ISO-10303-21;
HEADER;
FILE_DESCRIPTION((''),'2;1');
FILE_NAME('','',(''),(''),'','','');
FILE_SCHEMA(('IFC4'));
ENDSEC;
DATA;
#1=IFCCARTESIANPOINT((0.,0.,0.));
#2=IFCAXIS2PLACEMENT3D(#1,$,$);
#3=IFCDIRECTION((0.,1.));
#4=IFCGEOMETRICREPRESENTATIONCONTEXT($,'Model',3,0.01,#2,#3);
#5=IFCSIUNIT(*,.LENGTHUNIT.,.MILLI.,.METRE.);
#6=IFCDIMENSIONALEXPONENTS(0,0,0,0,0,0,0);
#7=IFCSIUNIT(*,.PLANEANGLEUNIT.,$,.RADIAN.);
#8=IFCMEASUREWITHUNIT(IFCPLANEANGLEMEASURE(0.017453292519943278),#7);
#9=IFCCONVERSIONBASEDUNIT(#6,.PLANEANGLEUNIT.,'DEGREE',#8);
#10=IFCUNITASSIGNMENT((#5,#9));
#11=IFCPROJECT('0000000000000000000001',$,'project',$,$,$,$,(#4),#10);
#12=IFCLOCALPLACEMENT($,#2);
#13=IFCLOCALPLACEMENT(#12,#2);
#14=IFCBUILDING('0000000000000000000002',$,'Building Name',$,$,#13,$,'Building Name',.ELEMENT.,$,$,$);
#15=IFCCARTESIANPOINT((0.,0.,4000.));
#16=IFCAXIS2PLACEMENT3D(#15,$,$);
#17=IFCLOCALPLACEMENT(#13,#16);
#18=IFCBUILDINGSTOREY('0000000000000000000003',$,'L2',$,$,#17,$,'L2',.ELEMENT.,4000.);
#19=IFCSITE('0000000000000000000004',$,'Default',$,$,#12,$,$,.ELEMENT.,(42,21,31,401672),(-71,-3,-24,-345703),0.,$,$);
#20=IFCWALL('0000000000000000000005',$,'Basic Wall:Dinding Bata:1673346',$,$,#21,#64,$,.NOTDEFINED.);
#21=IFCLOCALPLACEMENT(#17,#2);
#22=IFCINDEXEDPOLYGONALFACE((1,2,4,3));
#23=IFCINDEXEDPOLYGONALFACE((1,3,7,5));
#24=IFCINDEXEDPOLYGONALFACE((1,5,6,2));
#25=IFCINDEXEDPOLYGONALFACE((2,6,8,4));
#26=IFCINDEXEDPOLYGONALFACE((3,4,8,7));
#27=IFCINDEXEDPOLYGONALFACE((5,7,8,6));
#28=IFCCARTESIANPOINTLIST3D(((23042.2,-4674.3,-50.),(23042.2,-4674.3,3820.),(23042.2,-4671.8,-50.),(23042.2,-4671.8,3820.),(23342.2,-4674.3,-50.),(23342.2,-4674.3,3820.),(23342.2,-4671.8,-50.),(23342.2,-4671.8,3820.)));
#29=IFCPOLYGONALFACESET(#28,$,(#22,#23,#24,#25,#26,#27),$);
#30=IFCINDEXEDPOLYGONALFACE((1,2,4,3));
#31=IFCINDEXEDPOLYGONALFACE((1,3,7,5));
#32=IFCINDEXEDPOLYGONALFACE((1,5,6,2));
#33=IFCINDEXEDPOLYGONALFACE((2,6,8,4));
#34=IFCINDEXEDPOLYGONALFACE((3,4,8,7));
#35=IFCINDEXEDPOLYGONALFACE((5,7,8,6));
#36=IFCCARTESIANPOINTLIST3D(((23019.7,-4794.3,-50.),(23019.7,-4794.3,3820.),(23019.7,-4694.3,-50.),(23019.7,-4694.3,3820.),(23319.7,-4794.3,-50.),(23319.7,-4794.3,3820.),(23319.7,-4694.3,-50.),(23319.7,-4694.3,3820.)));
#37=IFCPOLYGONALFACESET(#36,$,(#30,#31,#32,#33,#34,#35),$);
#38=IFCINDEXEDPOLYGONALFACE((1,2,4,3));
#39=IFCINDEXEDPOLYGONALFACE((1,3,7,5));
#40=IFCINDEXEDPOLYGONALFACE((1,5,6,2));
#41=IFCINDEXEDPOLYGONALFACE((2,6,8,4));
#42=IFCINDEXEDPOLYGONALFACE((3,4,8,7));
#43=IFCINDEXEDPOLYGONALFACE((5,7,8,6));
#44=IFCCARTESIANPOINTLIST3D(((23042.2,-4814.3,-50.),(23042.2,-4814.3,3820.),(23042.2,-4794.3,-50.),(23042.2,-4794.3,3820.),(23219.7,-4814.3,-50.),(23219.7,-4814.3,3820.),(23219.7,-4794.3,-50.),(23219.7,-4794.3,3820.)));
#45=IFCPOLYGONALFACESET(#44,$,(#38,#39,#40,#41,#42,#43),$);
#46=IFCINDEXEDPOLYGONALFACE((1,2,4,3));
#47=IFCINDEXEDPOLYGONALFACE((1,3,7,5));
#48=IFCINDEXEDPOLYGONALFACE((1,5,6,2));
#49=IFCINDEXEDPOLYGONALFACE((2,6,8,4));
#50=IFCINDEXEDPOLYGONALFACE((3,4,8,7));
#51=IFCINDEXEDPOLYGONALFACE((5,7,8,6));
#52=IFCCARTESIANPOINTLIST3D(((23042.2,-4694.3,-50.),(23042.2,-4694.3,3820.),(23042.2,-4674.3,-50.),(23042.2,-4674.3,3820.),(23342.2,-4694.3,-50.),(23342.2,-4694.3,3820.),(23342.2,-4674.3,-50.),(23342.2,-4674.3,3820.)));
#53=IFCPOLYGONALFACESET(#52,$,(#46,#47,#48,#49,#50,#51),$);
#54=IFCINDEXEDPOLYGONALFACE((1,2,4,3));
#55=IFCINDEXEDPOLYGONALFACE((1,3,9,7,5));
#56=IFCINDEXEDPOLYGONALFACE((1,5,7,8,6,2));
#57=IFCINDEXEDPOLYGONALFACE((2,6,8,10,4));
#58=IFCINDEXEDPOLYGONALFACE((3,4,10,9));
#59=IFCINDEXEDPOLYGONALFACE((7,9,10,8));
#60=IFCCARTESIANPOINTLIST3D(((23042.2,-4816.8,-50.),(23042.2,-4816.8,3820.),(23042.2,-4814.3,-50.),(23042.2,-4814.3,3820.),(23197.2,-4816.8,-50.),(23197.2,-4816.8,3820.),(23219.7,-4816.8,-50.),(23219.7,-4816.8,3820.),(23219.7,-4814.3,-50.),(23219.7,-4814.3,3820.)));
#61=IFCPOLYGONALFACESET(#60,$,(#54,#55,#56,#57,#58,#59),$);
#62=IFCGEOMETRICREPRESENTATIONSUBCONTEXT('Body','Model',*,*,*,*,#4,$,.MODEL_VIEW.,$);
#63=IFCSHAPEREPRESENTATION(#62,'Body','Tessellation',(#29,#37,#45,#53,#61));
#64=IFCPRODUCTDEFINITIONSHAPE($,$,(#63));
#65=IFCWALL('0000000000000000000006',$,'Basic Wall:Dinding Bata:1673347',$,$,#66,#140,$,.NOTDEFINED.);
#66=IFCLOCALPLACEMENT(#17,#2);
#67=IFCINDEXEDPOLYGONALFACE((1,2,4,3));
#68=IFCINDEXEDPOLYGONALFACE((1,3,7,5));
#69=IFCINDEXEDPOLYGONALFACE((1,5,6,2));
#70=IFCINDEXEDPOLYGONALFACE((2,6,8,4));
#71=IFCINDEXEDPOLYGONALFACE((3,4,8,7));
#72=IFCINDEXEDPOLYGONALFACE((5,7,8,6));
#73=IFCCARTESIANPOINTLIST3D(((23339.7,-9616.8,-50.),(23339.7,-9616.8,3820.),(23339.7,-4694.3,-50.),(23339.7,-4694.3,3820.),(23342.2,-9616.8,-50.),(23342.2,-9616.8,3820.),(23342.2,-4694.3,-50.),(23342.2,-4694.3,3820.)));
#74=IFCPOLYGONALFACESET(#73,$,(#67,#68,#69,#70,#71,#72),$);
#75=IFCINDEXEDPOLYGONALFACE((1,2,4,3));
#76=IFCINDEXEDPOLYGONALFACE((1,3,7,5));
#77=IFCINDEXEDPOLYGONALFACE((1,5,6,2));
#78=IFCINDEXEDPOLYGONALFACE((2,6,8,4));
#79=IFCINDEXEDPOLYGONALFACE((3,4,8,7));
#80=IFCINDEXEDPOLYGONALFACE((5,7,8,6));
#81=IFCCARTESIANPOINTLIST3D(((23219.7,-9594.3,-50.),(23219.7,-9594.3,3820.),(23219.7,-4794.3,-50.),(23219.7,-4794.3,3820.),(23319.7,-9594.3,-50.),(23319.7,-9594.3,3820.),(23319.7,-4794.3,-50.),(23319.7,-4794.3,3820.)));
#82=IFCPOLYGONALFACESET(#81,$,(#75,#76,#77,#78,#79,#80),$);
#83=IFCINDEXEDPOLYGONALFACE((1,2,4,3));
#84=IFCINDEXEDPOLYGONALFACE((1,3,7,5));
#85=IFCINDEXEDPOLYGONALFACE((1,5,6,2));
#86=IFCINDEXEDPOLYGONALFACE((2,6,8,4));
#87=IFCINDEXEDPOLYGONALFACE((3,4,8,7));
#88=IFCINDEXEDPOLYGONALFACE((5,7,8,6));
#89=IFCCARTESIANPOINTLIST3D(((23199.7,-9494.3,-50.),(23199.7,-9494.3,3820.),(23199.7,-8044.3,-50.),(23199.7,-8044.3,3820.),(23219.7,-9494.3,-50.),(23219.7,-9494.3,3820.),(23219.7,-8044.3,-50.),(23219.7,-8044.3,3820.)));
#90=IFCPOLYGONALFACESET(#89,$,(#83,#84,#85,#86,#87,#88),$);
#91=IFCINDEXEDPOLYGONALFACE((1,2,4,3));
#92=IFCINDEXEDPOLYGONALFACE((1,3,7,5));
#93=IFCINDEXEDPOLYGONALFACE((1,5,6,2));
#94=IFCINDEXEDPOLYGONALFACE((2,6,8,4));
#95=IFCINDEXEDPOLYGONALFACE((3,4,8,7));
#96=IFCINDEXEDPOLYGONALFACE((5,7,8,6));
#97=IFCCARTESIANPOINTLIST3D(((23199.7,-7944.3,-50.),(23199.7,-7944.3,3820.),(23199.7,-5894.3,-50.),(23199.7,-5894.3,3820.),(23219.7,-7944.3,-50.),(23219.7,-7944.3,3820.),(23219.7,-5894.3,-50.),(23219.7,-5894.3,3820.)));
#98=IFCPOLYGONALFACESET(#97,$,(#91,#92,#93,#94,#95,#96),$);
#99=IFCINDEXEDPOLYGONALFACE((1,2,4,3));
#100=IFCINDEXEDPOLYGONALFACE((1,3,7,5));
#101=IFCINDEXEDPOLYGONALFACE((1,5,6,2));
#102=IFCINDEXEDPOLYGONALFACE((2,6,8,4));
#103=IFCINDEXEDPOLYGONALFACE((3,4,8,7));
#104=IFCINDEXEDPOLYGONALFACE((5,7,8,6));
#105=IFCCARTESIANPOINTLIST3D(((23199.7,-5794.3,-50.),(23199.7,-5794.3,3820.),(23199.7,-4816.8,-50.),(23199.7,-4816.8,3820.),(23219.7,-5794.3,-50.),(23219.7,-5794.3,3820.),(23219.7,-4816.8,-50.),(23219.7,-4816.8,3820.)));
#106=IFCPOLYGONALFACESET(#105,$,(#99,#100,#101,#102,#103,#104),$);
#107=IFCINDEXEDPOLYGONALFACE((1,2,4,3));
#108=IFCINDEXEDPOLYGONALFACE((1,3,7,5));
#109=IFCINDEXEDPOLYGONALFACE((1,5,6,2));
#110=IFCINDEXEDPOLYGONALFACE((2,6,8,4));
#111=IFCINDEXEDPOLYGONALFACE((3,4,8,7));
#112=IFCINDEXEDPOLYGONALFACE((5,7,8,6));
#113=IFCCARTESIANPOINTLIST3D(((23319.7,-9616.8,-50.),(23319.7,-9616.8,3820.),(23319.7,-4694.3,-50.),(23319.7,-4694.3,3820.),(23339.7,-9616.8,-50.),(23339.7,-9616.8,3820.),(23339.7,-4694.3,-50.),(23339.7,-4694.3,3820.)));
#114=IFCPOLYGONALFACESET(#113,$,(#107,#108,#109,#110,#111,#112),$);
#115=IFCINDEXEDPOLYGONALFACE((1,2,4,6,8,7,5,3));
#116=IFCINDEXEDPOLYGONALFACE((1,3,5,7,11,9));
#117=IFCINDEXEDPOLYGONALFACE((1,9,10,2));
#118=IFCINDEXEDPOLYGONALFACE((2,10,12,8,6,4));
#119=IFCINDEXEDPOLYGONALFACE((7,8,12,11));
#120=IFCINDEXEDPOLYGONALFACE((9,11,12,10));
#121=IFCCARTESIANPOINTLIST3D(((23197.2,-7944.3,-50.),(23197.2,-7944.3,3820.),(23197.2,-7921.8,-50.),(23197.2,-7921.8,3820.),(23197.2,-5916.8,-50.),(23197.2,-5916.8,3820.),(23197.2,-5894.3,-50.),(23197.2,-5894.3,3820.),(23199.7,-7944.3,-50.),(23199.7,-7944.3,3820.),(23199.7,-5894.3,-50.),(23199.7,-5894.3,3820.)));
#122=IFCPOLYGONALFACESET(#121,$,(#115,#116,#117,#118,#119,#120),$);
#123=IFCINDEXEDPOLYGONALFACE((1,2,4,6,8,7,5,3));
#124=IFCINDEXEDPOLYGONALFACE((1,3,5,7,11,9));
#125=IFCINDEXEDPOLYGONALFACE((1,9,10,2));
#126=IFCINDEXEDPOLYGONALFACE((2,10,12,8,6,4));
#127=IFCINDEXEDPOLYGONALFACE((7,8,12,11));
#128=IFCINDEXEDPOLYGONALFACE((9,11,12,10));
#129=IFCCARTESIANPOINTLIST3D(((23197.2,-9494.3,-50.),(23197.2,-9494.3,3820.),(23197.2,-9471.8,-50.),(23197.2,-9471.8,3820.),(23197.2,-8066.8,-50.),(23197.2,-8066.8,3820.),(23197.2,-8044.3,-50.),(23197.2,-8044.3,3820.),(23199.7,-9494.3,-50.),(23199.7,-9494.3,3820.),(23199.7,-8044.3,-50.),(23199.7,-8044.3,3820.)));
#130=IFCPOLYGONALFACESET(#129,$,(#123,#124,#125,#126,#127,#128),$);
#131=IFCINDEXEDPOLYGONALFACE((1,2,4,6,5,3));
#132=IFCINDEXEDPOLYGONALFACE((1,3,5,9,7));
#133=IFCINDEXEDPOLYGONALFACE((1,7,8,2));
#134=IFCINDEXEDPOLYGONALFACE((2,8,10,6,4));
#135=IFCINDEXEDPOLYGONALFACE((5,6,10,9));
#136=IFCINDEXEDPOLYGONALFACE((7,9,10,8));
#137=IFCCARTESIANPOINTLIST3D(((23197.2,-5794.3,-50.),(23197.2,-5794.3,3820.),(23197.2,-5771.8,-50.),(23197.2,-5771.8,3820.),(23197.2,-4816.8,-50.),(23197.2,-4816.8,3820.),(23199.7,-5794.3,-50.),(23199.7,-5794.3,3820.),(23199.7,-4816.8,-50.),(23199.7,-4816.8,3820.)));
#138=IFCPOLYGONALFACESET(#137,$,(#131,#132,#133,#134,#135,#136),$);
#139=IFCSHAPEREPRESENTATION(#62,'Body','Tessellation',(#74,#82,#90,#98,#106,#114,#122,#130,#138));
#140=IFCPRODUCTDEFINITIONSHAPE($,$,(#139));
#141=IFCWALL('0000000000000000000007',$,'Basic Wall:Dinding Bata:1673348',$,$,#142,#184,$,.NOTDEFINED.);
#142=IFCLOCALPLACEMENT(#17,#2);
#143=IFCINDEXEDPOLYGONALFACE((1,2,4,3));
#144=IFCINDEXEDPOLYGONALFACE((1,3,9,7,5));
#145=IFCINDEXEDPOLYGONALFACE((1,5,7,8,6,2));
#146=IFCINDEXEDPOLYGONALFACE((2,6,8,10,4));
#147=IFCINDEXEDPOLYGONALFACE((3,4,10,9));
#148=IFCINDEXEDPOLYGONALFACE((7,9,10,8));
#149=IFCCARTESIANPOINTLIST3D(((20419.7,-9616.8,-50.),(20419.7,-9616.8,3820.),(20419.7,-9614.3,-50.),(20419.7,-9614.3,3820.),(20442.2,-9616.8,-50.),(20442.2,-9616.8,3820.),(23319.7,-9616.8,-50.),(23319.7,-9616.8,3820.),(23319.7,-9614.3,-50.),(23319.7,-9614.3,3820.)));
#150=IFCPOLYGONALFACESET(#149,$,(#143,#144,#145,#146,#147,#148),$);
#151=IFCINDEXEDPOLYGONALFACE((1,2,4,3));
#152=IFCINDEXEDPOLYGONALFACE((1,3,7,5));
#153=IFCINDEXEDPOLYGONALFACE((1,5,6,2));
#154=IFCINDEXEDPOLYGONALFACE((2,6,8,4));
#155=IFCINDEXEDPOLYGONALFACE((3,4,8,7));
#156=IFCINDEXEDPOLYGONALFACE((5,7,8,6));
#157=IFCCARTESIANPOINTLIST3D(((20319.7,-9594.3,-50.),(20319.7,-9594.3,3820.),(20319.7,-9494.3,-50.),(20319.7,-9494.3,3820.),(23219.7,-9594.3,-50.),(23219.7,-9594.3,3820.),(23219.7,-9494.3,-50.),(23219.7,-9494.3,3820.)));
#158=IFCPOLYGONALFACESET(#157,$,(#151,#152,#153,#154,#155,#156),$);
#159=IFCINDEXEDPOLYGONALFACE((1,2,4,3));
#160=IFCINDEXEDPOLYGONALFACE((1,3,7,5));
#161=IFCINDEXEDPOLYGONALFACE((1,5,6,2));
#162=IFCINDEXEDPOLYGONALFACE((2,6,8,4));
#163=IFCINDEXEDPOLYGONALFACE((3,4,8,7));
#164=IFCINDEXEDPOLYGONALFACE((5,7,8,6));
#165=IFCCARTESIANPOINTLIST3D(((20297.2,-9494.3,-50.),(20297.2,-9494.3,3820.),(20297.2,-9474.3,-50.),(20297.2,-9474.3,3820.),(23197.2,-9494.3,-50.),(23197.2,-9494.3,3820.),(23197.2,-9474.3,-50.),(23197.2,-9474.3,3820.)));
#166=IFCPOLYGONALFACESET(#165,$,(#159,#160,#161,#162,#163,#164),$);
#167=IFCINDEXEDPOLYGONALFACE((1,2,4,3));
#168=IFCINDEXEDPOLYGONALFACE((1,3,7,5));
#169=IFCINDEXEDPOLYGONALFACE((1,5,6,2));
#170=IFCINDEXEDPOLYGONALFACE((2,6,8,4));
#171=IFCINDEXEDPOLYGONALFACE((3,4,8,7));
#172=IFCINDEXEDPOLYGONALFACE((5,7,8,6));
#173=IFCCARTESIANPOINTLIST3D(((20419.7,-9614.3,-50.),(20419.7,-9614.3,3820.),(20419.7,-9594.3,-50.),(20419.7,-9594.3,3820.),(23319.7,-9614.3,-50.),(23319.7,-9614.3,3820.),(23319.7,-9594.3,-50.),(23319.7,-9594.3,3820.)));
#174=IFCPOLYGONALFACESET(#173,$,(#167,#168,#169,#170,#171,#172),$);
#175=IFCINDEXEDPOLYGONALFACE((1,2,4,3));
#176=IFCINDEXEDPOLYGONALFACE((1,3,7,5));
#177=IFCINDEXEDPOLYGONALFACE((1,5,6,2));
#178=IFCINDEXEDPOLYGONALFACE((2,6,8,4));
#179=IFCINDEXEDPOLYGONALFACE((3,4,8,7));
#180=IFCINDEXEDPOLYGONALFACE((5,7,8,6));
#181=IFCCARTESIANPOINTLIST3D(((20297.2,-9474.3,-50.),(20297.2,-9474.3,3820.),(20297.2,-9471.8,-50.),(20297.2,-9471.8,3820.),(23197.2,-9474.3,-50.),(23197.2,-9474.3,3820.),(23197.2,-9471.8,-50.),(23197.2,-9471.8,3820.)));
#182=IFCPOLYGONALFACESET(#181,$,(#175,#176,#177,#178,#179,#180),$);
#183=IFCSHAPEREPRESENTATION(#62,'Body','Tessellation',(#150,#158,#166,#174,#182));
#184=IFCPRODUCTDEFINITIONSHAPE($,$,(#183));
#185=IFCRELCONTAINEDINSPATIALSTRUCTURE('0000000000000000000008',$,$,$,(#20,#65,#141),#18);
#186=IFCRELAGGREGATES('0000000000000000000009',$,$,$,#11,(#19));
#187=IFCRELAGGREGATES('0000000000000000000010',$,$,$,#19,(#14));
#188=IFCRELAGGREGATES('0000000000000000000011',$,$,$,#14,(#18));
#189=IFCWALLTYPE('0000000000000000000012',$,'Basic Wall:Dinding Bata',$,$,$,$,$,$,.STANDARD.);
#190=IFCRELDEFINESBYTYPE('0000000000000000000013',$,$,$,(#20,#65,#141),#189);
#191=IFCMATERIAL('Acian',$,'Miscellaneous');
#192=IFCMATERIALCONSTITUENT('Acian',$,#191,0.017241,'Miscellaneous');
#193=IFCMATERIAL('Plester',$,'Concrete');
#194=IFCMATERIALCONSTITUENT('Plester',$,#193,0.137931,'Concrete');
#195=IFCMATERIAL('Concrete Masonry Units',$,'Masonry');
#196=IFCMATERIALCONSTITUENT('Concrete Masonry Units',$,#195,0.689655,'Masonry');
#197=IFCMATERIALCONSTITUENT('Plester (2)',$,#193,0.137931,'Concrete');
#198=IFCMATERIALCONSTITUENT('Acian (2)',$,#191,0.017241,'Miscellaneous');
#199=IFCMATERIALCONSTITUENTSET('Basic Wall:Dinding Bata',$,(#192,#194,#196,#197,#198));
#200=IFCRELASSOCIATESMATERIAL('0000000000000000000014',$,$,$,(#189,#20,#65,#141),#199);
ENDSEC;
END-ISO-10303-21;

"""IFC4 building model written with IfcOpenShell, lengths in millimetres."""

from ifc_helpers import new_model, entity, si_unit, converted_unit, direction, frame, origin, place, context, subcontext, project, spatial, indexed_curve, outline, extrude, material, constituent, constituent_set, type_object, element, save


model = new_model("IFC4")

# Units and contexts
model_context = context("Model", 3, precision=0.01, world=origin(), true_north=direction((0.0, 1.0)))
body_context = subcontext(model_context, "Body", "Model", "MODEL_VIEW")
ifc_project = project(units=[si_unit("LENGTHUNIT", "METRE", prefix="MILLI"), converted_unit("PLANEANGLEUNIT", "DEGREE", entity("IfcPlaneAngleMeasure", 0.017453292519943278), si_unit("PLANEANGLEUNIT", "RADIAN"), dimensions=[0, 0, 0, 0, 0, 0, 0])], contexts=[model_context])

# Site, building, storey
site_placement = place(None, origin())
site = spatial("IfcSite", under=ifc_project, at=site_placement, Name="Default", CompositionType="ELEMENT", RefLatitude=(42, 21, 31, 401672), RefLongitude=(-71, -3, -24, -345703), RefElevation=0.0)
building_placement = place(site_placement, origin())
building = spatial("IfcBuilding", under=site, at=building_placement, Name="Building Name", LongName="Building Name", CompositionType="ELEMENT")
storey_placement = place(building_placement, frame((0.0, 0.0, 4000.0)))
storey = spatial("IfcBuildingStorey", under=building, at=storey_placement, Name="L2", LongName="L2", CompositionType="ELEMENT", Elevation=4000.0)

# Walls
ifc_material_1 = material(Name="Acian", Category="Miscellaneous")
ifc_constituent_1 = constituent(ifc_material_1, Name="Acian", Category="Miscellaneous", fraction=0.017241)
ifc_material_2 = material(Name="Plester", Category="Concrete")
ifc_constituent_2 = constituent(ifc_material_2, Name="Plester", Category="Concrete", fraction=0.137931)
ifc_material_3 = material(Name="Concrete Masonry Units", Category="Masonry")
ifc_constituent_3 = constituent(ifc_material_3, Name="Concrete Masonry Units", Category="Masonry", fraction=0.689655)
ifc_constituent_4 = constituent(ifc_material_2, Name="Plester (2)", Category="Concrete", fraction=0.137931)
ifc_constituent_5 = constituent(ifc_material_1, Name="Acian (2)", Category="Miscellaneous", fraction=0.017241)
ifc_constituent_set = constituent_set(constituents=[ifc_constituent_1, ifc_constituent_2, ifc_constituent_3, ifc_constituent_4, ifc_constituent_5], Name="Basic Wall:Dinding Bata")
wall_type = type_object("IfcWallType", Name="Basic Wall:Dinding Bata", PredefinedType="STANDARD", material=ifc_constituent_set)
wall_1_placement = place(storey_placement, frame((23042.2, -4744.3, -50.0)))
element("IfcWall", 1, at=wall_1_placement, inside=storey, type_object=wall_type, material=ifc_constituent_set, Name="Basic Wall:Dinding Bata:1673346", PredefinedType="NOTDEFINED", context=body_context, shape_type="SweptSolid", body=[
    extrude(outline(indexed_curve([(-1.3, -150.0), (1.2, -150.0), (1.3, 150.0), (-1.2, 150.0), (-1.3, -150.0)], self_intersect=False)), frame((150.0, 71.3, 0.0), z_axis=(0.0, 0.0, 1.0), x_axis=(0.0, -1.0, 0.0)), (0.0, 0.0, 1.0), 3870.0),
    extrude(outline(indexed_curve([(-150.0, -50.0), (150.0, -50.0), (150.0, 50.0), (-150.0, 50.0), (-150.0, -50.0)], self_intersect=False)), frame((127.5, 0.0, 0.0)), (0.0, 0.0, 1.0), 3870.0),
    extrude(outline(indexed_curve([(-88.8, -10.0), (88.8, -10.0), (88.8, 10.0), (-88.8, 10.0), (-88.8, -10.0)], self_intersect=False)), frame((88.8, -60.0, 0.0)), (0.0, 0.0, 1.0), 3870.0),
    extrude(outline(indexed_curve([(-150.0, -10.0), (150.0, -10.0), (150.0, 10.0), (-150.0, 10.0), (-150.0, -10.0)], self_intersect=False)), frame((150.0, 60.0, 0.0)), (0.0, 0.0, 1.0), 3870.0),
    extrude(outline(indexed_curve([(53.0, -1.0), (75.5, -1.0), (75.5, 1.5), (-102.0, 1.5), (-102.0, -1.0), (53.0, -1.0)], self_intersect=False)), frame((102.0, -71.5, 0.0)), (0.0, 0.0, 1.0), 3870.0),
])
wall_2_placement = place(storey_placement, frame((23269.7, -4816.8, -50.0), z_axis=(0.0, 0.0, 1.0), x_axis=(0.0, -1.0, 0.0)))
element("IfcWall", 2, at=wall_2_placement, inside=storey, type_object=wall_type, material=ifc_constituent_set, Name="Basic Wall:Dinding Bata:1673347", PredefinedType="NOTDEFINED", context=body_context, shape_type="SweptSolid", body=[
    extrude(outline(indexed_curve([(-1.3, -2461.3), (1.2, -2461.3), (1.3, 2461.3), (-1.2, 2461.3), (-1.3, -2461.3)], self_intersect=False)), frame((2338.8, 71.3, 0.0), z_axis=(0.0, 0.0, 1.0), x_axis=(0.0, -1.0, 0.0)), (0.0, 0.0, 1.0), 3870.0),
    extrude(outline(indexed_curve([(-2400.0, -50.0), (2400.0, -50.0), (2400.0, 50.0), (-2400.0, 50.0), (-2400.0, -50.0)], self_intersect=False)), frame((2377.5, 0.0, 0.0)), (0.0, 0.0, 1.0), 3870.0),
    extrude(outline(indexed_curve([(-725.0, -10.0), (725.0, -10.0), (725.0, 10.0), (-725.0, 10.0), (-725.0, -10.0)], self_intersect=False)), frame((3952.5, -60.0, 0.0), z_axis=(0.0, 0.0, 1.0), x_axis=(-1.0, 0.0, 0.0)), (0.0, 0.0, 1.0), 3870.0),
    extrude(outline(indexed_curve([(-1025.0, -10.0), (1025.0, -10.0), (1025.0, 10.0), (-1025.0, 10.0), (-1025.0, -10.0)], self_intersect=False)), frame((2102.5, -60.0, 0.0)), (0.0, 0.0, 1.0), 3870.0),
    extrude(outline(indexed_curve([(-488.7, -10.0), (488.7, -10.0), (488.7, 10.0), (-488.7, 10.0), (-488.7, -10.0)], self_intersect=False)), frame((488.7, -60.0, 0.0)), (0.0, 0.0, 1.0), 3870.0),
    extrude(outline(indexed_curve([(-2461.3, -10.0), (2461.3, -10.0), (2461.3, 10.0), (-2461.3, 10.0), (-2461.3, -10.0)], self_intersect=False)), frame((2338.8, 60.0, 0.0)), (0.0, 0.0, 1.0), 3870.0),
    extrude(outline(indexed_curve([(1002.5, -0.8), (1025.0, -0.8), (1025.0, 1.7), (-1025.0, 1.7), (-1025.0, -0.8), (-1002.5, -0.8), (1002.5, -0.8)], self_intersect=False)), frame((2102.5, -71.7, 0.0)), (0.0, 0.0, 1.0), 3870.0),
    extrude(outline(indexed_curve([(702.5, -0.8), (725.0, -0.8), (725.0, 1.7), (-725.0, 1.7), (-725.0, -0.8), (-702.5, -0.8), (702.5, -0.8)], self_intersect=False)), frame((3952.5, -71.7, 0.0)), (0.0, 0.0, 1.0), 3870.0),
    extrude(outline(indexed_curve([(373.0, -1.0), (395.5, -1.0), (395.5, 1.5), (-582.0, 1.5), (-582.0, -1.0), (373.0, -1.0)], self_intersect=False)), frame((582.0, -71.5, 0.0)), (0.0, 0.0, 1.0), 3870.0),
])
wall_3_placement = place(storey_placement, frame((23197.2, -9544.3, -50.0), z_axis=(0.0, 0.0, 1.0), x_axis=(-1.0, 0.0, 0.0)))
element("IfcWall", 3, at=wall_3_placement, inside=storey, type_object=wall_type, material=ifc_constituent_set, Name="Basic Wall:Dinding Bata:1673348", PredefinedType="NOTDEFINED", context=body_context, shape_type="SweptSolid", body=[
    extrude(outline(indexed_curve([(-1142.0, -1.0), (1735.5, -1.0), (1735.5, 1.5), (-1164.5, 1.5), (-1164.5, -1.0), (-1142.0, -1.0)], self_intersect=False)), frame((1613.0, 71.5, 0.0), z_axis=(0.0, 0.0, 1.0), x_axis=(-1.0, 0.0, 0.0)), (0.0, 0.0, 1.0), 3870.0),
    extrude(outline(indexed_curve([(-1450.0, -50.0), (1450.0, -50.0), (1450.0, 50.0), (-1450.0, 50.0), (-1450.0, -50.0)], self_intersect=False)), frame((1427.5, 0.0, 0.0)), (0.0, 0.0, 1.0), 3870.0),
    extrude(outline(indexed_curve([(-1450.0, -10.0), (1450.0, -10.0), (1450.0, 10.0), (-1450.0, 10.0), (-1450.0, -10.0)], self_intersect=False)), frame((1450.0, -60.0, 0.0)), (0.0, 0.0, 1.0), 3870.0),
    extrude(outline(indexed_curve([(-1450.0, -10.0), (1450.0, -10.0), (1450.0, 10.0), (-1450.0, 10.0), (-1450.0, -10.0)], self_intersect=False)), frame((1327.5, 60.0, 0.0)), (0.0, 0.0, 1.0), 3870.0),
    extrude(outline(indexed_curve([(-1.3, -1450.0), (1.2, -1450.0), (1.3, 1450.0), (-1.2, 1450.0), (-1.3, -1450.0)], self_intersect=False)), frame((1450.0, -71.3, 0.0), z_axis=(0.0, 0.0, 1.0), x_axis=(0.0, 1.0, 0.0)), (0.0, 0.0, 1.0), 3870.0),
])

save(model, "model.ifc")
